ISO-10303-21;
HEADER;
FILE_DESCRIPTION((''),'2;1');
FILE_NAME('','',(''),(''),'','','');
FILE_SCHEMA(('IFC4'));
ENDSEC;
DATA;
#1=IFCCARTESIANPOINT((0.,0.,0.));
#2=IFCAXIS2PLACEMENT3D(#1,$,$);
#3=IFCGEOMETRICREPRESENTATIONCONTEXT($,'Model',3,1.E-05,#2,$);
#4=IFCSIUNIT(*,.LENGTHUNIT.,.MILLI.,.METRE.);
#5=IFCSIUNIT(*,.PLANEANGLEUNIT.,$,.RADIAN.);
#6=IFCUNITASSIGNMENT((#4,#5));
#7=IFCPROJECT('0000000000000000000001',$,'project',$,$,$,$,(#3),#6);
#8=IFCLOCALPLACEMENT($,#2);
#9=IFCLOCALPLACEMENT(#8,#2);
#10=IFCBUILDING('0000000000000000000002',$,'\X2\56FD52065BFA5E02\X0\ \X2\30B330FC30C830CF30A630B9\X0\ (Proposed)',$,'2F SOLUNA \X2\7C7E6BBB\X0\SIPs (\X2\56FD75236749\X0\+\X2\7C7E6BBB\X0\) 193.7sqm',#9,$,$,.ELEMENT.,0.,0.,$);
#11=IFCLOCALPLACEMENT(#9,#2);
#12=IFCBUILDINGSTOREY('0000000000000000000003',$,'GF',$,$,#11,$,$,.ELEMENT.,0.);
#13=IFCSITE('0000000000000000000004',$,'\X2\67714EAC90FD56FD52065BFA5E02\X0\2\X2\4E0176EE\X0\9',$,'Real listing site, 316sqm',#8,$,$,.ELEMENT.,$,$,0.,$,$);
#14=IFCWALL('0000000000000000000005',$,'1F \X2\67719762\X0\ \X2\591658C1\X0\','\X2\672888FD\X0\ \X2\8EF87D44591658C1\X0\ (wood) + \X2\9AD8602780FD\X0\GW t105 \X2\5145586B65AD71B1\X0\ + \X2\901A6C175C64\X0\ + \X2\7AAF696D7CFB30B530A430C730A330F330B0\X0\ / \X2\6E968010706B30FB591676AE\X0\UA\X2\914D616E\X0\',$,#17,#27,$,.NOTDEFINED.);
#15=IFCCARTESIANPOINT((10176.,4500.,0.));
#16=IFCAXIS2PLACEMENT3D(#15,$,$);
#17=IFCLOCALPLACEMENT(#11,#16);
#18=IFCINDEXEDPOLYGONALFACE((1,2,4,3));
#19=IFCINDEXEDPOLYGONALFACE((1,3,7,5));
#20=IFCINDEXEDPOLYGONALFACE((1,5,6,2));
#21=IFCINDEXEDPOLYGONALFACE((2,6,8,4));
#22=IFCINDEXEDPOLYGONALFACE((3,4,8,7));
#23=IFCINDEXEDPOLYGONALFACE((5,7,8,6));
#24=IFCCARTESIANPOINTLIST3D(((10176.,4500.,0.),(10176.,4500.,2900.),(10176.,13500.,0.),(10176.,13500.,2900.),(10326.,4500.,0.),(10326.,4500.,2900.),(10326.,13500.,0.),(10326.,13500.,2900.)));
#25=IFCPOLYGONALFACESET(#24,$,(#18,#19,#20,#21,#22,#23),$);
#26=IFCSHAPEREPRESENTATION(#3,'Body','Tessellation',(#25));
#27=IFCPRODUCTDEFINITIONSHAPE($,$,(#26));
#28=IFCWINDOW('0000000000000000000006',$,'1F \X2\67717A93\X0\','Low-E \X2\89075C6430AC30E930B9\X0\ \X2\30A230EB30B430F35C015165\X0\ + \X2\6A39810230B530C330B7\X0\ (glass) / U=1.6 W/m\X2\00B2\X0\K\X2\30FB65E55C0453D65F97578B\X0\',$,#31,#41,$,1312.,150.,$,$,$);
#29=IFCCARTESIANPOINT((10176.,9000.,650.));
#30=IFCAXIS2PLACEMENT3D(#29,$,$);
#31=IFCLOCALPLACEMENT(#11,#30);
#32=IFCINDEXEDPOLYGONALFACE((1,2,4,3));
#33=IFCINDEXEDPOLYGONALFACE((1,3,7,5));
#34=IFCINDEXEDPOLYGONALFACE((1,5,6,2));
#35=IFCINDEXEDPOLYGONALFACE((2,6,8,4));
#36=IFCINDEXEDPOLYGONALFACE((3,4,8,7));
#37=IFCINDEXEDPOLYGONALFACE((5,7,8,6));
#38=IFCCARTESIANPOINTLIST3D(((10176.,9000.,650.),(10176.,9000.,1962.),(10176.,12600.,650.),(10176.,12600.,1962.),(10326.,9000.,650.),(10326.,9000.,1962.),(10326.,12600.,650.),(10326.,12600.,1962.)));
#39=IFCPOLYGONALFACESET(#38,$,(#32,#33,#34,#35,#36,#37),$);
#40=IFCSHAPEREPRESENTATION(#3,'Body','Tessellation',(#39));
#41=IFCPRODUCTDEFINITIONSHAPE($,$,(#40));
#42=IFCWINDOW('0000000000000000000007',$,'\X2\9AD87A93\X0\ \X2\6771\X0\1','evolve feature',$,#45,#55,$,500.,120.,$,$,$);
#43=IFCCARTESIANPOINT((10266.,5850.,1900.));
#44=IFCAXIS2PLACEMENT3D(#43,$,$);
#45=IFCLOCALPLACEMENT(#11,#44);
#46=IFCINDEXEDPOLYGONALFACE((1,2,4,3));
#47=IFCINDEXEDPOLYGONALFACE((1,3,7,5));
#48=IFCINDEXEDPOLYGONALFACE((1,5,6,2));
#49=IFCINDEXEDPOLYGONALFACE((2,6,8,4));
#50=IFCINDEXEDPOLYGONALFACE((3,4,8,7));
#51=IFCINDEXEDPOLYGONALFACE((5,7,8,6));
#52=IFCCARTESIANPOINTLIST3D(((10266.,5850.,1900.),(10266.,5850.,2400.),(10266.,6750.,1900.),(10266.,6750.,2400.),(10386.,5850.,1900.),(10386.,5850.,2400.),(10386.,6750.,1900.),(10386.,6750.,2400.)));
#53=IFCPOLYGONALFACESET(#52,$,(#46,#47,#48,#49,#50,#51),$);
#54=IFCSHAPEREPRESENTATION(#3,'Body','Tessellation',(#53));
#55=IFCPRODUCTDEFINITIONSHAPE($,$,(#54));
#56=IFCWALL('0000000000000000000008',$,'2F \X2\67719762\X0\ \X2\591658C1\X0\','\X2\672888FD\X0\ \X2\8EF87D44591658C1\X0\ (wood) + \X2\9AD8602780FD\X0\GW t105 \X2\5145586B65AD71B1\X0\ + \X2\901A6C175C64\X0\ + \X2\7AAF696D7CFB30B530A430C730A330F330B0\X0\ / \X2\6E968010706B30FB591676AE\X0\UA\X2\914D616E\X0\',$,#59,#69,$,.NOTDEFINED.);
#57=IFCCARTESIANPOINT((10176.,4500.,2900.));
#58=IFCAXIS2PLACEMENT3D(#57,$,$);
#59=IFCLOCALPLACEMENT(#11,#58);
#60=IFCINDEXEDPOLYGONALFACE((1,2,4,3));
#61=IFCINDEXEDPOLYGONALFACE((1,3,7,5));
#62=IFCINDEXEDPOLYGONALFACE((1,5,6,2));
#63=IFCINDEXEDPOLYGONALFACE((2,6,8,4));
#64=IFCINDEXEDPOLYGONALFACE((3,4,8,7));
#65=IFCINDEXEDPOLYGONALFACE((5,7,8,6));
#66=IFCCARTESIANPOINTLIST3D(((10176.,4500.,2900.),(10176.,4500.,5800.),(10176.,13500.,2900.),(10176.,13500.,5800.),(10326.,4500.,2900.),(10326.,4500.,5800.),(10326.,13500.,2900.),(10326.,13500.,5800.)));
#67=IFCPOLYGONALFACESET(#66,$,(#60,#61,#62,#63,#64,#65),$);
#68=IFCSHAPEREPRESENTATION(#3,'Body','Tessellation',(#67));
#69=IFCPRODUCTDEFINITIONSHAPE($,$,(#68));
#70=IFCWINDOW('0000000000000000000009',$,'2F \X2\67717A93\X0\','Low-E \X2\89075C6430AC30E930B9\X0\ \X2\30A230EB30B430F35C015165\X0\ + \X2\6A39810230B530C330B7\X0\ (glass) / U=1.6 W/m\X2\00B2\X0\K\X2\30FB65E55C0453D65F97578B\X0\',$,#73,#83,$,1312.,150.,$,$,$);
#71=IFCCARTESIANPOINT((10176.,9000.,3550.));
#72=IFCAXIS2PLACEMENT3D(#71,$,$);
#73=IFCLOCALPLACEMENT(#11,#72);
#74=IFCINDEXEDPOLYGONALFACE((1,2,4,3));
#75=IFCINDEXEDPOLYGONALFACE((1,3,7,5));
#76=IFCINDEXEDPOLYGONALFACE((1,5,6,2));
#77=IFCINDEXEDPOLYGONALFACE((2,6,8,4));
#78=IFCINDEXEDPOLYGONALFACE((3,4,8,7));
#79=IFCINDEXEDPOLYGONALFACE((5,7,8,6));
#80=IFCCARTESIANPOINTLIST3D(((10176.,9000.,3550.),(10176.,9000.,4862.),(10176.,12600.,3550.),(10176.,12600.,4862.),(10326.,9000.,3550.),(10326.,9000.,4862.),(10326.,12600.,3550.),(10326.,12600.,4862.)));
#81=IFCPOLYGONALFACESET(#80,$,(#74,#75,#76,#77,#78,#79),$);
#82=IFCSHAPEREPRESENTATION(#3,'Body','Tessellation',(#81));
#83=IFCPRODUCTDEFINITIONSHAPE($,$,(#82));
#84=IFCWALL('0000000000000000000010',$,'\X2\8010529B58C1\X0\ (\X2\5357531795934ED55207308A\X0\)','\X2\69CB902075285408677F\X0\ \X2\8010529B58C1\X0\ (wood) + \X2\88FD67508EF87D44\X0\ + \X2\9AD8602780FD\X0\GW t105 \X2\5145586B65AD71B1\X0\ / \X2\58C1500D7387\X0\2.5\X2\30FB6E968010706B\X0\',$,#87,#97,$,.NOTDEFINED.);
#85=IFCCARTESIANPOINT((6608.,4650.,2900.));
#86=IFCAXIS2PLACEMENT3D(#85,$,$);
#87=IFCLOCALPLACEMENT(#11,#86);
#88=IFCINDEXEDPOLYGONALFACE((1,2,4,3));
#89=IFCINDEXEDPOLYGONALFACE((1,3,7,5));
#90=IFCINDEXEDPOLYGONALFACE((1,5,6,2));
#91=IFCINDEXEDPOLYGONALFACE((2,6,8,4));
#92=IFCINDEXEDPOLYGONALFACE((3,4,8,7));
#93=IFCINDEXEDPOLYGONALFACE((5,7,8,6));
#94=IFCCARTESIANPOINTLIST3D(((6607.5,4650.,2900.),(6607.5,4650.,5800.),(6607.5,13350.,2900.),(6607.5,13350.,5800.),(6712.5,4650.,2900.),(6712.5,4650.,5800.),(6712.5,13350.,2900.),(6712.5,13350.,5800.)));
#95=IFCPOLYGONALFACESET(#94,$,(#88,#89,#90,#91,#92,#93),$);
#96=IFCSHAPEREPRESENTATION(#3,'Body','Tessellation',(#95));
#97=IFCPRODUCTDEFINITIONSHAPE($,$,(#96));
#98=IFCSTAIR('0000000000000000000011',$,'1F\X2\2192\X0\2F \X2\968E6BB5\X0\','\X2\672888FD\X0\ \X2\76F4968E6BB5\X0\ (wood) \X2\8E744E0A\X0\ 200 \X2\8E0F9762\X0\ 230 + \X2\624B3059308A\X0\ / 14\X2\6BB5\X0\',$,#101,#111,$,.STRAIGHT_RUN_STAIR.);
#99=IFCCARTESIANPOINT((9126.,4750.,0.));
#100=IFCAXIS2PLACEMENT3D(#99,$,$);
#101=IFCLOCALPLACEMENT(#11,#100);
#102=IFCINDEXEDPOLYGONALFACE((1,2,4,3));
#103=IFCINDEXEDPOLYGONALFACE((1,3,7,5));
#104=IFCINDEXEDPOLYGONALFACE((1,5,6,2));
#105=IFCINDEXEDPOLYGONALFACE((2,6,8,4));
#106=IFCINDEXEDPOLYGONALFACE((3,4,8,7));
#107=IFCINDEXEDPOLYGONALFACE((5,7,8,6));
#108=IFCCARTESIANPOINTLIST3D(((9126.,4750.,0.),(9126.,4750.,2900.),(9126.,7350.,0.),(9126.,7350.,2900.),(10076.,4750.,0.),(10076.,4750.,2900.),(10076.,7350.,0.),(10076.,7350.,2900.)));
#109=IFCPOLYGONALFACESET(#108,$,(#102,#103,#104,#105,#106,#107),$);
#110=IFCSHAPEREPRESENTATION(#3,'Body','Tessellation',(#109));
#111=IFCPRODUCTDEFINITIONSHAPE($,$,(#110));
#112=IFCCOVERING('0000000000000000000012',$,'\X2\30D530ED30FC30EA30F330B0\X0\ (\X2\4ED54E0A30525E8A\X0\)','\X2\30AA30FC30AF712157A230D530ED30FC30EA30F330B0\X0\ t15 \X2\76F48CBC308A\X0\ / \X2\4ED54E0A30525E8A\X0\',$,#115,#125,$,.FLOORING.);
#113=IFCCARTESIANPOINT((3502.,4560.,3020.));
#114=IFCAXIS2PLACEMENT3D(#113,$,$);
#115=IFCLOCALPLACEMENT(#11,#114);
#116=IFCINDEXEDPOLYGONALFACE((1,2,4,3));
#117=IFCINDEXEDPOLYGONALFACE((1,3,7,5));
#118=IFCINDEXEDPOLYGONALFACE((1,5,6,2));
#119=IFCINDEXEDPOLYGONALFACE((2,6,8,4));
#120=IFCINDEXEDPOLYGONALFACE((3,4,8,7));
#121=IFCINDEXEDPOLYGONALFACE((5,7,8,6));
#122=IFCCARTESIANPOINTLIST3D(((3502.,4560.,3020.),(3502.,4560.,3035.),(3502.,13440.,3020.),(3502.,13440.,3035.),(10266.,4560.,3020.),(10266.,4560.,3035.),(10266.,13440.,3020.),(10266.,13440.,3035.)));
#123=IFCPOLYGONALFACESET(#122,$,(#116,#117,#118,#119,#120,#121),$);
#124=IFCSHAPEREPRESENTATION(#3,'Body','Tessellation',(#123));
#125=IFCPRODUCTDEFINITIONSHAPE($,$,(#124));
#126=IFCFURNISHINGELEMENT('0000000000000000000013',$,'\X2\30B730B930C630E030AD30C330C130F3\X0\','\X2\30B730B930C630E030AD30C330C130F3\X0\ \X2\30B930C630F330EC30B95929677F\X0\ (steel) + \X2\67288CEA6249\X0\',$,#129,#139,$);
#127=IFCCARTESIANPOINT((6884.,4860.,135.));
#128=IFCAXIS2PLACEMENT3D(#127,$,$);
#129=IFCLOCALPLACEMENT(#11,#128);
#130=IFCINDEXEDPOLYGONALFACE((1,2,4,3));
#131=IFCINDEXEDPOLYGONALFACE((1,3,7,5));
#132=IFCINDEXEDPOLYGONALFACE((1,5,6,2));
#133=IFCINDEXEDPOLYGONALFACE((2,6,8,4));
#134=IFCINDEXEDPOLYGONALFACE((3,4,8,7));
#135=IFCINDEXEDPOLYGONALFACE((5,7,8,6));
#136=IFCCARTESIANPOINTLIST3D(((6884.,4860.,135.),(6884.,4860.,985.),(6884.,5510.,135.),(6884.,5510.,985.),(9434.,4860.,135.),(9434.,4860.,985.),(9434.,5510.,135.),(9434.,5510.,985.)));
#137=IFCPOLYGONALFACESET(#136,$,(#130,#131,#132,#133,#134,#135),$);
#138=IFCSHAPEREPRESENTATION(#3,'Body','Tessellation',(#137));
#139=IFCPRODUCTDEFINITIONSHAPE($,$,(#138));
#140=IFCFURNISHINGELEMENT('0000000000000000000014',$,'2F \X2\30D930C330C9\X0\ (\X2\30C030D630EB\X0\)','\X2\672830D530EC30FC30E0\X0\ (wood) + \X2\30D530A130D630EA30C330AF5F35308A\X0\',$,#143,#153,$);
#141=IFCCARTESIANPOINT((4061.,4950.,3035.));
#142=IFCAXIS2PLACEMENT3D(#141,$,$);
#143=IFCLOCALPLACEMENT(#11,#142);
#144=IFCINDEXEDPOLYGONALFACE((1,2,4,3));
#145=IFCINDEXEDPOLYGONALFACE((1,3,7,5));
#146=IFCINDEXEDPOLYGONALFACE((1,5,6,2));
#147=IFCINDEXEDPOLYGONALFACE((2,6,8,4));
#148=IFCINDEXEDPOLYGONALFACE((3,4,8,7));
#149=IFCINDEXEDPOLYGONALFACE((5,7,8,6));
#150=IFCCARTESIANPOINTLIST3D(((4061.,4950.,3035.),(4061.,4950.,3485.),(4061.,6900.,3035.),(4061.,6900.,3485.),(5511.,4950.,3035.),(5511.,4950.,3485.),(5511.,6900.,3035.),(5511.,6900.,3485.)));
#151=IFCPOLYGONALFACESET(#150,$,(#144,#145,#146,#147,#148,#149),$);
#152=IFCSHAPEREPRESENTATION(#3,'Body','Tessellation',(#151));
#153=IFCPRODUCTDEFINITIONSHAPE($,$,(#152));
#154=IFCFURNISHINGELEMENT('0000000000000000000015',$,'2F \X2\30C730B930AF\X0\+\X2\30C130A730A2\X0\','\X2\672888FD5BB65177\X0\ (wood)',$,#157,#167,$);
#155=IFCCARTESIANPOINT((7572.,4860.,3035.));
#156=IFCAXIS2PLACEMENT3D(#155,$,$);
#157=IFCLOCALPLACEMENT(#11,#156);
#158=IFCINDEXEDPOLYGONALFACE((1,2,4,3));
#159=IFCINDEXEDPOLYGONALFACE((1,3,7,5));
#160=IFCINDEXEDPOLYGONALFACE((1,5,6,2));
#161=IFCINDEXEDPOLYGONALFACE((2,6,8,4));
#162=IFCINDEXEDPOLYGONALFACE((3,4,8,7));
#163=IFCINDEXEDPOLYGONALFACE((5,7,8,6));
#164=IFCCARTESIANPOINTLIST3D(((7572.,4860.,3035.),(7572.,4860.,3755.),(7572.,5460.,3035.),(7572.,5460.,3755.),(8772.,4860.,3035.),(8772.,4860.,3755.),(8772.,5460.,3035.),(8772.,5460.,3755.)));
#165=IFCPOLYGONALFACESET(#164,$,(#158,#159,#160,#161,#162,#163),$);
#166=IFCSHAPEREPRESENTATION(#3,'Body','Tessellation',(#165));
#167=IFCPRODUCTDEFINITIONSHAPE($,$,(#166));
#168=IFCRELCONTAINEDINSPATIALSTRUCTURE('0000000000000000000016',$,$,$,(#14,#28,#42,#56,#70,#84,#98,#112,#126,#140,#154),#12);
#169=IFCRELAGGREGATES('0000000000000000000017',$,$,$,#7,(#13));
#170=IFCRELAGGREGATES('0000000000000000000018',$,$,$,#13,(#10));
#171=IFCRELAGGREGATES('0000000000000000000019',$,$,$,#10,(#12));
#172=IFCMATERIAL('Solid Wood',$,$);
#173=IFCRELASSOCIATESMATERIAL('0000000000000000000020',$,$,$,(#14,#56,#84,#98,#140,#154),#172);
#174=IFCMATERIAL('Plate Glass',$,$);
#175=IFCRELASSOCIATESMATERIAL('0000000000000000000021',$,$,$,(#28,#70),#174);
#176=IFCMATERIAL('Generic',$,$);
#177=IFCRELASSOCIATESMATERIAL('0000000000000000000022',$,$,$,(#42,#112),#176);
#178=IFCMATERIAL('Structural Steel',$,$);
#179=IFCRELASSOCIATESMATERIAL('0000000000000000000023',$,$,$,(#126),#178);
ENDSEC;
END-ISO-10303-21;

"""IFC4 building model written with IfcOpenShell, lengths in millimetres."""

from ifc_helpers import new_model, si_unit, frame, frame_2d, origin, place, context, project, spatial, rectangle, extrude, material, element, fill, save


model = new_model("IFC4")

# Units and contexts
model_context = context("Model", 3, precision=1e-05, world=origin())
ifc_project = project(units=[si_unit("LENGTHUNIT", "METRE", prefix="MILLI"), si_unit("PLANEANGLEUNIT", "RADIAN")], contexts=[model_context])

# Site, building, storey
site_placement = place(None, origin())
site = spatial("IfcSite", under=ifc_project, at=site_placement, Name="東京都国分寺市2丁目9", ObjectType="Real listing site, 316sqm", CompositionType="ELEMENT", RefElevation=0.0)
building_placement = place(site_placement, origin())
building = spatial("IfcBuilding", under=site, at=building_placement, Name="国分寺市 コートハウス (Proposed)", ObjectType="2F SOLUNA 籾殻SIPs (国産杉+籾殻) 193.7sqm", CompositionType="ELEMENT", ElevationOfRefHeight=0.0, ElevationOfTerrain=0.0)
storey_placement = place(building_placement, origin())
storey = spatial("IfcBuildingStorey", under=building, at=storey_placement, Name="GF", CompositionType="ELEMENT", Elevation=0.0)

# Shared definitions
ifc_material_1 = material(Name="Solid Wood")

# Wall, openings, windows
wall_1_placement = place(storey_placement, frame((10176.0, 4500.0, 0.0)))
wall_1 = element("IfcWall", 1, at=wall_1_placement, inside=storey, material=ifc_material_1, Name="1F 東面 外壁", Description="木製 軸組外壁 (wood) + 高性能GW t105 充填断熱 + 通気層 + 窯業系サイディング / 準耐火・外皮UA配慮", PredefinedType="NOTDEFINED", context=model_context, shape_type="SweptSolid", body=[
    extrude(rectangle(XDim=150.0, YDim=9000.0, at=frame_2d((75.0, 4500.0))), frame((10176.0, 4500.0, 0.0)), (0.0, 0.0, 1.0), 2900.0),
])
opening_1_placement = place(storey_placement, frame((10176.0, 9000.0, 650.0)))
opening_1 = element("IfcOpeningElement", 2, at=opening_1_placement, cuts=wall_1, PredefinedType="NOTDEFINED", context=model_context, shape_type="SweptSolid", body=[
    extrude(rectangle(XDim=150.0, YDim=3600.0, at=frame_2d((75.0, 1800.0))), frame((10176.0, 9000.0, 650.0)), (0.0, 0.0, 1.0), 1312.0),
])
opening_2_placement = place(storey_placement, frame((10266.0, 5850.0, 1900.0)))
opening_2 = element("IfcOpeningElement", 3, at=opening_2_placement, cuts=wall_1, PredefinedType="NOTDEFINED", context=model_context, shape_type="SweptSolid", body=[
    extrude(rectangle(XDim=120.0, YDim=900.0, at=frame_2d((60.0, 450.0))), frame((10266.0, 5850.0, 1900.0)), (0.0, 0.0, 1.0), 500.0),
])
ifc_material_2 = material(Name="Plate Glass")
window_1_placement = place(storey_placement, frame((10176.0, 9000.0, 650.0)))
window_1 = element("IfcWindow", 4, at=window_1_placement, inside=storey, material=ifc_material_2, Name="1F 東窓", Description="Low-E 複層ガラス アルゴン封入 + 樹脂サッシ (glass) / U=1.6 W/m²K・日射取得型", OverallHeight=1312.0, OverallWidth=150.0, context=model_context, shape_type="SweptSolid", body=[
    extrude(rectangle(XDim=150.0, YDim=3600.0, at=frame_2d((75.0, 1800.0))), frame((10176.0, 9000.0, 650.0)), (0.0, 0.0, 1.0), 1312.0),
])
fill(opening_1, window_1)
ifc_material_3 = material(Name="Generic")
window_2_placement = place(storey_placement, frame((10266.0, 5850.0, 1900.0)))
window_2 = element("IfcWindow", 5, at=window_2_placement, inside=storey, material=ifc_material_3, Name="高窓 東1", Description="evolve feature", OverallHeight=500.0, OverallWidth=120.0, context=model_context, shape_type="SweptSolid", body=[
    extrude(rectangle(XDim=120.0, YDim=900.0, at=frame_2d((60.0, 450.0))), frame((10266.0, 5850.0, 1900.0)), (0.0, 0.0, 1.0), 500.0),
])
fill(opening_2, window_2)

# Wall, opening, window
wall_2_placement = place(storey_placement, frame((10176.0, 4500.0, 2900.0)))
wall_2 = element("IfcWall", 6, at=wall_2_placement, inside=storey, material=ifc_material_1, Name="2F 東面 外壁", Description="木製 軸組外壁 (wood) + 高性能GW t105 充填断熱 + 通気層 + 窯業系サイディング / 準耐火・外皮UA配慮", PredefinedType="NOTDEFINED", context=model_context, shape_type="SweptSolid", body=[
    extrude(rectangle(XDim=150.0, YDim=9000.0, at=frame_2d((75.0, 4500.0))), frame((10176.0, 4500.0, 2900.0)), (0.0, 0.0, 1.0), 2900.0),
])
opening_3_placement = place(storey_placement, frame((10176.0, 9000.0, 3550.0)))
opening_3 = element("IfcOpeningElement", 7, at=opening_3_placement, cuts=wall_2, PredefinedType="NOTDEFINED", context=model_context, shape_type="SweptSolid", body=[
    extrude(rectangle(XDim=150.0, YDim=3600.0, at=frame_2d((75.0, 1800.0))), frame((10176.0, 9000.0, 3550.0)), (0.0, 0.0, 1.0), 1312.0),
])
window_3_placement = place(storey_placement, frame((10176.0, 9000.0, 3550.0)))
window_3 = element("IfcWindow", 8, at=window_3_placement, inside=storey, material=ifc_material_2, Name="2F 東窓", Description="Low-E 複層ガラス アルゴン封入 + 樹脂サッシ (glass) / U=1.6 W/m²K・日射取得型", OverallHeight=1312.0, OverallWidth=150.0, context=model_context, shape_type="SweptSolid", body=[
    extrude(rectangle(XDim=150.0, YDim=3600.0, at=frame_2d((75.0, 1800.0))), frame((10176.0, 9000.0, 3550.0)), (0.0, 0.0, 1.0), 1312.0),
])
fill(opening_3, window_3)

# Wall
wall_3_placement = place(storey_placement, frame((6608.0, 4650.0, 2900.0)))
element("IfcWall", 9, at=wall_3_placement, inside=storey, material=ifc_material_1, Name="耐力壁 (南北間仕切り)", Description="構造用合板 耐力壁 (wood) + 製材軸組 + 高性能GW t105 充填断熱 / 壁倍率2.5・準耐火", PredefinedType="NOTDEFINED", context=model_context, shape_type="SweptSolid", body=[
    extrude(rectangle(XDim=105.0, YDim=8700.0, at=frame_2d((52.0, 4350.0))), frame((6608.0, 4650.0, 2900.0)), (0.0, 0.0, 1.0), 2900.0),
])

# Stair
stair_placement = place(storey_placement, frame((9126.0, 4750.0, 0.0)))
element("IfcStair", 10, at=stair_placement, inside=storey, material=ifc_material_1, Name="1F→2F 階段", Description="木製 直階段 (wood) 蹴上 200 踏面 230 + 手すり / 14段", PredefinedType="STRAIGHT_RUN_STAIR", context=model_context, shape_type="SweptSolid", body=[
    extrude(rectangle(XDim=950.0, YDim=2600.0, at=frame_2d((475.0, 1300.0))), frame((9126.0, 4750.0, 0.0)), (0.0, 0.0, 1.0), 2900.0),
])

# Covering
covering_placement = place(storey_placement, frame((3502.0, 4560.0, 3020.0)))
element("IfcCovering", 11, at=covering_placement, inside=storey, material=ifc_material_3, Name="フローリング (仕上げ床)", Description="オーク無垢フローリング t15 直貼り / 仕上げ床", PredefinedType="FLOORING", context=model_context, shape_type="SweptSolid", body=[
    extrude(rectangle(XDim=6764.0, YDim=8880.0, at=frame_2d((3382.0, 4440.0))), frame((3502.0, 4560.0, 3020.0)), (0.0, 0.0, 1.0), 15.0),
])

# Furnishing elements
ifc_material_4 = material(Name="Structural Steel")
furnishing_1_placement = place(storey_placement, frame((6884.0, 4860.0, 135.0)))
element("IfcFurnishingElement", 12, at=furnishing_1_placement, inside=storey, material=ifc_material_4, Name="システムキッチン", Description="システムキッチン ステンレス天板 (steel) + 木質扉", context=model_context, shape_type="SweptSolid", body=[
    extrude(rectangle(XDim=2550.0, YDim=650.0, at=frame_2d((1275.0, 325.0))), frame((6884.0, 4860.0, 135.0)), (0.0, 0.0, 1.0), 850.0),
])
furnishing_2_placement = place(storey_placement, frame((4061.0, 4950.0, 3035.0)))
element("IfcFurnishingElement", 13, at=furnishing_2_placement, inside=storey, material=ifc_material_1, Name="2F ベッド (ダブル)", Description="木フレーム (wood) + ファブリック張り", context=model_context, shape_type="SweptSolid", body=[
    extrude(rectangle(XDim=1450.0, YDim=1950.0, at=frame_2d((725.0, 975.0))), frame((4061.0, 4950.0, 3035.0)), (0.0, 0.0, 1.0), 450.0),
])
furnishing_3_placement = place(storey_placement, frame((7572.0, 4860.0, 3035.0)))
element("IfcFurnishingElement", 14, at=furnishing_3_placement, inside=storey, material=ifc_material_1, Name="2F デスク+チェア", Description="木製家具 (wood)", context=model_context, shape_type="SweptSolid", body=[
    extrude(rectangle(XDim=1200.0, YDim=600.0, at=frame_2d((600.0, 300.0))), frame((7572.0, 4860.0, 3035.0)), (0.0, 0.0, 1.0), 720.0),
])

save(model, "model.ifc")
